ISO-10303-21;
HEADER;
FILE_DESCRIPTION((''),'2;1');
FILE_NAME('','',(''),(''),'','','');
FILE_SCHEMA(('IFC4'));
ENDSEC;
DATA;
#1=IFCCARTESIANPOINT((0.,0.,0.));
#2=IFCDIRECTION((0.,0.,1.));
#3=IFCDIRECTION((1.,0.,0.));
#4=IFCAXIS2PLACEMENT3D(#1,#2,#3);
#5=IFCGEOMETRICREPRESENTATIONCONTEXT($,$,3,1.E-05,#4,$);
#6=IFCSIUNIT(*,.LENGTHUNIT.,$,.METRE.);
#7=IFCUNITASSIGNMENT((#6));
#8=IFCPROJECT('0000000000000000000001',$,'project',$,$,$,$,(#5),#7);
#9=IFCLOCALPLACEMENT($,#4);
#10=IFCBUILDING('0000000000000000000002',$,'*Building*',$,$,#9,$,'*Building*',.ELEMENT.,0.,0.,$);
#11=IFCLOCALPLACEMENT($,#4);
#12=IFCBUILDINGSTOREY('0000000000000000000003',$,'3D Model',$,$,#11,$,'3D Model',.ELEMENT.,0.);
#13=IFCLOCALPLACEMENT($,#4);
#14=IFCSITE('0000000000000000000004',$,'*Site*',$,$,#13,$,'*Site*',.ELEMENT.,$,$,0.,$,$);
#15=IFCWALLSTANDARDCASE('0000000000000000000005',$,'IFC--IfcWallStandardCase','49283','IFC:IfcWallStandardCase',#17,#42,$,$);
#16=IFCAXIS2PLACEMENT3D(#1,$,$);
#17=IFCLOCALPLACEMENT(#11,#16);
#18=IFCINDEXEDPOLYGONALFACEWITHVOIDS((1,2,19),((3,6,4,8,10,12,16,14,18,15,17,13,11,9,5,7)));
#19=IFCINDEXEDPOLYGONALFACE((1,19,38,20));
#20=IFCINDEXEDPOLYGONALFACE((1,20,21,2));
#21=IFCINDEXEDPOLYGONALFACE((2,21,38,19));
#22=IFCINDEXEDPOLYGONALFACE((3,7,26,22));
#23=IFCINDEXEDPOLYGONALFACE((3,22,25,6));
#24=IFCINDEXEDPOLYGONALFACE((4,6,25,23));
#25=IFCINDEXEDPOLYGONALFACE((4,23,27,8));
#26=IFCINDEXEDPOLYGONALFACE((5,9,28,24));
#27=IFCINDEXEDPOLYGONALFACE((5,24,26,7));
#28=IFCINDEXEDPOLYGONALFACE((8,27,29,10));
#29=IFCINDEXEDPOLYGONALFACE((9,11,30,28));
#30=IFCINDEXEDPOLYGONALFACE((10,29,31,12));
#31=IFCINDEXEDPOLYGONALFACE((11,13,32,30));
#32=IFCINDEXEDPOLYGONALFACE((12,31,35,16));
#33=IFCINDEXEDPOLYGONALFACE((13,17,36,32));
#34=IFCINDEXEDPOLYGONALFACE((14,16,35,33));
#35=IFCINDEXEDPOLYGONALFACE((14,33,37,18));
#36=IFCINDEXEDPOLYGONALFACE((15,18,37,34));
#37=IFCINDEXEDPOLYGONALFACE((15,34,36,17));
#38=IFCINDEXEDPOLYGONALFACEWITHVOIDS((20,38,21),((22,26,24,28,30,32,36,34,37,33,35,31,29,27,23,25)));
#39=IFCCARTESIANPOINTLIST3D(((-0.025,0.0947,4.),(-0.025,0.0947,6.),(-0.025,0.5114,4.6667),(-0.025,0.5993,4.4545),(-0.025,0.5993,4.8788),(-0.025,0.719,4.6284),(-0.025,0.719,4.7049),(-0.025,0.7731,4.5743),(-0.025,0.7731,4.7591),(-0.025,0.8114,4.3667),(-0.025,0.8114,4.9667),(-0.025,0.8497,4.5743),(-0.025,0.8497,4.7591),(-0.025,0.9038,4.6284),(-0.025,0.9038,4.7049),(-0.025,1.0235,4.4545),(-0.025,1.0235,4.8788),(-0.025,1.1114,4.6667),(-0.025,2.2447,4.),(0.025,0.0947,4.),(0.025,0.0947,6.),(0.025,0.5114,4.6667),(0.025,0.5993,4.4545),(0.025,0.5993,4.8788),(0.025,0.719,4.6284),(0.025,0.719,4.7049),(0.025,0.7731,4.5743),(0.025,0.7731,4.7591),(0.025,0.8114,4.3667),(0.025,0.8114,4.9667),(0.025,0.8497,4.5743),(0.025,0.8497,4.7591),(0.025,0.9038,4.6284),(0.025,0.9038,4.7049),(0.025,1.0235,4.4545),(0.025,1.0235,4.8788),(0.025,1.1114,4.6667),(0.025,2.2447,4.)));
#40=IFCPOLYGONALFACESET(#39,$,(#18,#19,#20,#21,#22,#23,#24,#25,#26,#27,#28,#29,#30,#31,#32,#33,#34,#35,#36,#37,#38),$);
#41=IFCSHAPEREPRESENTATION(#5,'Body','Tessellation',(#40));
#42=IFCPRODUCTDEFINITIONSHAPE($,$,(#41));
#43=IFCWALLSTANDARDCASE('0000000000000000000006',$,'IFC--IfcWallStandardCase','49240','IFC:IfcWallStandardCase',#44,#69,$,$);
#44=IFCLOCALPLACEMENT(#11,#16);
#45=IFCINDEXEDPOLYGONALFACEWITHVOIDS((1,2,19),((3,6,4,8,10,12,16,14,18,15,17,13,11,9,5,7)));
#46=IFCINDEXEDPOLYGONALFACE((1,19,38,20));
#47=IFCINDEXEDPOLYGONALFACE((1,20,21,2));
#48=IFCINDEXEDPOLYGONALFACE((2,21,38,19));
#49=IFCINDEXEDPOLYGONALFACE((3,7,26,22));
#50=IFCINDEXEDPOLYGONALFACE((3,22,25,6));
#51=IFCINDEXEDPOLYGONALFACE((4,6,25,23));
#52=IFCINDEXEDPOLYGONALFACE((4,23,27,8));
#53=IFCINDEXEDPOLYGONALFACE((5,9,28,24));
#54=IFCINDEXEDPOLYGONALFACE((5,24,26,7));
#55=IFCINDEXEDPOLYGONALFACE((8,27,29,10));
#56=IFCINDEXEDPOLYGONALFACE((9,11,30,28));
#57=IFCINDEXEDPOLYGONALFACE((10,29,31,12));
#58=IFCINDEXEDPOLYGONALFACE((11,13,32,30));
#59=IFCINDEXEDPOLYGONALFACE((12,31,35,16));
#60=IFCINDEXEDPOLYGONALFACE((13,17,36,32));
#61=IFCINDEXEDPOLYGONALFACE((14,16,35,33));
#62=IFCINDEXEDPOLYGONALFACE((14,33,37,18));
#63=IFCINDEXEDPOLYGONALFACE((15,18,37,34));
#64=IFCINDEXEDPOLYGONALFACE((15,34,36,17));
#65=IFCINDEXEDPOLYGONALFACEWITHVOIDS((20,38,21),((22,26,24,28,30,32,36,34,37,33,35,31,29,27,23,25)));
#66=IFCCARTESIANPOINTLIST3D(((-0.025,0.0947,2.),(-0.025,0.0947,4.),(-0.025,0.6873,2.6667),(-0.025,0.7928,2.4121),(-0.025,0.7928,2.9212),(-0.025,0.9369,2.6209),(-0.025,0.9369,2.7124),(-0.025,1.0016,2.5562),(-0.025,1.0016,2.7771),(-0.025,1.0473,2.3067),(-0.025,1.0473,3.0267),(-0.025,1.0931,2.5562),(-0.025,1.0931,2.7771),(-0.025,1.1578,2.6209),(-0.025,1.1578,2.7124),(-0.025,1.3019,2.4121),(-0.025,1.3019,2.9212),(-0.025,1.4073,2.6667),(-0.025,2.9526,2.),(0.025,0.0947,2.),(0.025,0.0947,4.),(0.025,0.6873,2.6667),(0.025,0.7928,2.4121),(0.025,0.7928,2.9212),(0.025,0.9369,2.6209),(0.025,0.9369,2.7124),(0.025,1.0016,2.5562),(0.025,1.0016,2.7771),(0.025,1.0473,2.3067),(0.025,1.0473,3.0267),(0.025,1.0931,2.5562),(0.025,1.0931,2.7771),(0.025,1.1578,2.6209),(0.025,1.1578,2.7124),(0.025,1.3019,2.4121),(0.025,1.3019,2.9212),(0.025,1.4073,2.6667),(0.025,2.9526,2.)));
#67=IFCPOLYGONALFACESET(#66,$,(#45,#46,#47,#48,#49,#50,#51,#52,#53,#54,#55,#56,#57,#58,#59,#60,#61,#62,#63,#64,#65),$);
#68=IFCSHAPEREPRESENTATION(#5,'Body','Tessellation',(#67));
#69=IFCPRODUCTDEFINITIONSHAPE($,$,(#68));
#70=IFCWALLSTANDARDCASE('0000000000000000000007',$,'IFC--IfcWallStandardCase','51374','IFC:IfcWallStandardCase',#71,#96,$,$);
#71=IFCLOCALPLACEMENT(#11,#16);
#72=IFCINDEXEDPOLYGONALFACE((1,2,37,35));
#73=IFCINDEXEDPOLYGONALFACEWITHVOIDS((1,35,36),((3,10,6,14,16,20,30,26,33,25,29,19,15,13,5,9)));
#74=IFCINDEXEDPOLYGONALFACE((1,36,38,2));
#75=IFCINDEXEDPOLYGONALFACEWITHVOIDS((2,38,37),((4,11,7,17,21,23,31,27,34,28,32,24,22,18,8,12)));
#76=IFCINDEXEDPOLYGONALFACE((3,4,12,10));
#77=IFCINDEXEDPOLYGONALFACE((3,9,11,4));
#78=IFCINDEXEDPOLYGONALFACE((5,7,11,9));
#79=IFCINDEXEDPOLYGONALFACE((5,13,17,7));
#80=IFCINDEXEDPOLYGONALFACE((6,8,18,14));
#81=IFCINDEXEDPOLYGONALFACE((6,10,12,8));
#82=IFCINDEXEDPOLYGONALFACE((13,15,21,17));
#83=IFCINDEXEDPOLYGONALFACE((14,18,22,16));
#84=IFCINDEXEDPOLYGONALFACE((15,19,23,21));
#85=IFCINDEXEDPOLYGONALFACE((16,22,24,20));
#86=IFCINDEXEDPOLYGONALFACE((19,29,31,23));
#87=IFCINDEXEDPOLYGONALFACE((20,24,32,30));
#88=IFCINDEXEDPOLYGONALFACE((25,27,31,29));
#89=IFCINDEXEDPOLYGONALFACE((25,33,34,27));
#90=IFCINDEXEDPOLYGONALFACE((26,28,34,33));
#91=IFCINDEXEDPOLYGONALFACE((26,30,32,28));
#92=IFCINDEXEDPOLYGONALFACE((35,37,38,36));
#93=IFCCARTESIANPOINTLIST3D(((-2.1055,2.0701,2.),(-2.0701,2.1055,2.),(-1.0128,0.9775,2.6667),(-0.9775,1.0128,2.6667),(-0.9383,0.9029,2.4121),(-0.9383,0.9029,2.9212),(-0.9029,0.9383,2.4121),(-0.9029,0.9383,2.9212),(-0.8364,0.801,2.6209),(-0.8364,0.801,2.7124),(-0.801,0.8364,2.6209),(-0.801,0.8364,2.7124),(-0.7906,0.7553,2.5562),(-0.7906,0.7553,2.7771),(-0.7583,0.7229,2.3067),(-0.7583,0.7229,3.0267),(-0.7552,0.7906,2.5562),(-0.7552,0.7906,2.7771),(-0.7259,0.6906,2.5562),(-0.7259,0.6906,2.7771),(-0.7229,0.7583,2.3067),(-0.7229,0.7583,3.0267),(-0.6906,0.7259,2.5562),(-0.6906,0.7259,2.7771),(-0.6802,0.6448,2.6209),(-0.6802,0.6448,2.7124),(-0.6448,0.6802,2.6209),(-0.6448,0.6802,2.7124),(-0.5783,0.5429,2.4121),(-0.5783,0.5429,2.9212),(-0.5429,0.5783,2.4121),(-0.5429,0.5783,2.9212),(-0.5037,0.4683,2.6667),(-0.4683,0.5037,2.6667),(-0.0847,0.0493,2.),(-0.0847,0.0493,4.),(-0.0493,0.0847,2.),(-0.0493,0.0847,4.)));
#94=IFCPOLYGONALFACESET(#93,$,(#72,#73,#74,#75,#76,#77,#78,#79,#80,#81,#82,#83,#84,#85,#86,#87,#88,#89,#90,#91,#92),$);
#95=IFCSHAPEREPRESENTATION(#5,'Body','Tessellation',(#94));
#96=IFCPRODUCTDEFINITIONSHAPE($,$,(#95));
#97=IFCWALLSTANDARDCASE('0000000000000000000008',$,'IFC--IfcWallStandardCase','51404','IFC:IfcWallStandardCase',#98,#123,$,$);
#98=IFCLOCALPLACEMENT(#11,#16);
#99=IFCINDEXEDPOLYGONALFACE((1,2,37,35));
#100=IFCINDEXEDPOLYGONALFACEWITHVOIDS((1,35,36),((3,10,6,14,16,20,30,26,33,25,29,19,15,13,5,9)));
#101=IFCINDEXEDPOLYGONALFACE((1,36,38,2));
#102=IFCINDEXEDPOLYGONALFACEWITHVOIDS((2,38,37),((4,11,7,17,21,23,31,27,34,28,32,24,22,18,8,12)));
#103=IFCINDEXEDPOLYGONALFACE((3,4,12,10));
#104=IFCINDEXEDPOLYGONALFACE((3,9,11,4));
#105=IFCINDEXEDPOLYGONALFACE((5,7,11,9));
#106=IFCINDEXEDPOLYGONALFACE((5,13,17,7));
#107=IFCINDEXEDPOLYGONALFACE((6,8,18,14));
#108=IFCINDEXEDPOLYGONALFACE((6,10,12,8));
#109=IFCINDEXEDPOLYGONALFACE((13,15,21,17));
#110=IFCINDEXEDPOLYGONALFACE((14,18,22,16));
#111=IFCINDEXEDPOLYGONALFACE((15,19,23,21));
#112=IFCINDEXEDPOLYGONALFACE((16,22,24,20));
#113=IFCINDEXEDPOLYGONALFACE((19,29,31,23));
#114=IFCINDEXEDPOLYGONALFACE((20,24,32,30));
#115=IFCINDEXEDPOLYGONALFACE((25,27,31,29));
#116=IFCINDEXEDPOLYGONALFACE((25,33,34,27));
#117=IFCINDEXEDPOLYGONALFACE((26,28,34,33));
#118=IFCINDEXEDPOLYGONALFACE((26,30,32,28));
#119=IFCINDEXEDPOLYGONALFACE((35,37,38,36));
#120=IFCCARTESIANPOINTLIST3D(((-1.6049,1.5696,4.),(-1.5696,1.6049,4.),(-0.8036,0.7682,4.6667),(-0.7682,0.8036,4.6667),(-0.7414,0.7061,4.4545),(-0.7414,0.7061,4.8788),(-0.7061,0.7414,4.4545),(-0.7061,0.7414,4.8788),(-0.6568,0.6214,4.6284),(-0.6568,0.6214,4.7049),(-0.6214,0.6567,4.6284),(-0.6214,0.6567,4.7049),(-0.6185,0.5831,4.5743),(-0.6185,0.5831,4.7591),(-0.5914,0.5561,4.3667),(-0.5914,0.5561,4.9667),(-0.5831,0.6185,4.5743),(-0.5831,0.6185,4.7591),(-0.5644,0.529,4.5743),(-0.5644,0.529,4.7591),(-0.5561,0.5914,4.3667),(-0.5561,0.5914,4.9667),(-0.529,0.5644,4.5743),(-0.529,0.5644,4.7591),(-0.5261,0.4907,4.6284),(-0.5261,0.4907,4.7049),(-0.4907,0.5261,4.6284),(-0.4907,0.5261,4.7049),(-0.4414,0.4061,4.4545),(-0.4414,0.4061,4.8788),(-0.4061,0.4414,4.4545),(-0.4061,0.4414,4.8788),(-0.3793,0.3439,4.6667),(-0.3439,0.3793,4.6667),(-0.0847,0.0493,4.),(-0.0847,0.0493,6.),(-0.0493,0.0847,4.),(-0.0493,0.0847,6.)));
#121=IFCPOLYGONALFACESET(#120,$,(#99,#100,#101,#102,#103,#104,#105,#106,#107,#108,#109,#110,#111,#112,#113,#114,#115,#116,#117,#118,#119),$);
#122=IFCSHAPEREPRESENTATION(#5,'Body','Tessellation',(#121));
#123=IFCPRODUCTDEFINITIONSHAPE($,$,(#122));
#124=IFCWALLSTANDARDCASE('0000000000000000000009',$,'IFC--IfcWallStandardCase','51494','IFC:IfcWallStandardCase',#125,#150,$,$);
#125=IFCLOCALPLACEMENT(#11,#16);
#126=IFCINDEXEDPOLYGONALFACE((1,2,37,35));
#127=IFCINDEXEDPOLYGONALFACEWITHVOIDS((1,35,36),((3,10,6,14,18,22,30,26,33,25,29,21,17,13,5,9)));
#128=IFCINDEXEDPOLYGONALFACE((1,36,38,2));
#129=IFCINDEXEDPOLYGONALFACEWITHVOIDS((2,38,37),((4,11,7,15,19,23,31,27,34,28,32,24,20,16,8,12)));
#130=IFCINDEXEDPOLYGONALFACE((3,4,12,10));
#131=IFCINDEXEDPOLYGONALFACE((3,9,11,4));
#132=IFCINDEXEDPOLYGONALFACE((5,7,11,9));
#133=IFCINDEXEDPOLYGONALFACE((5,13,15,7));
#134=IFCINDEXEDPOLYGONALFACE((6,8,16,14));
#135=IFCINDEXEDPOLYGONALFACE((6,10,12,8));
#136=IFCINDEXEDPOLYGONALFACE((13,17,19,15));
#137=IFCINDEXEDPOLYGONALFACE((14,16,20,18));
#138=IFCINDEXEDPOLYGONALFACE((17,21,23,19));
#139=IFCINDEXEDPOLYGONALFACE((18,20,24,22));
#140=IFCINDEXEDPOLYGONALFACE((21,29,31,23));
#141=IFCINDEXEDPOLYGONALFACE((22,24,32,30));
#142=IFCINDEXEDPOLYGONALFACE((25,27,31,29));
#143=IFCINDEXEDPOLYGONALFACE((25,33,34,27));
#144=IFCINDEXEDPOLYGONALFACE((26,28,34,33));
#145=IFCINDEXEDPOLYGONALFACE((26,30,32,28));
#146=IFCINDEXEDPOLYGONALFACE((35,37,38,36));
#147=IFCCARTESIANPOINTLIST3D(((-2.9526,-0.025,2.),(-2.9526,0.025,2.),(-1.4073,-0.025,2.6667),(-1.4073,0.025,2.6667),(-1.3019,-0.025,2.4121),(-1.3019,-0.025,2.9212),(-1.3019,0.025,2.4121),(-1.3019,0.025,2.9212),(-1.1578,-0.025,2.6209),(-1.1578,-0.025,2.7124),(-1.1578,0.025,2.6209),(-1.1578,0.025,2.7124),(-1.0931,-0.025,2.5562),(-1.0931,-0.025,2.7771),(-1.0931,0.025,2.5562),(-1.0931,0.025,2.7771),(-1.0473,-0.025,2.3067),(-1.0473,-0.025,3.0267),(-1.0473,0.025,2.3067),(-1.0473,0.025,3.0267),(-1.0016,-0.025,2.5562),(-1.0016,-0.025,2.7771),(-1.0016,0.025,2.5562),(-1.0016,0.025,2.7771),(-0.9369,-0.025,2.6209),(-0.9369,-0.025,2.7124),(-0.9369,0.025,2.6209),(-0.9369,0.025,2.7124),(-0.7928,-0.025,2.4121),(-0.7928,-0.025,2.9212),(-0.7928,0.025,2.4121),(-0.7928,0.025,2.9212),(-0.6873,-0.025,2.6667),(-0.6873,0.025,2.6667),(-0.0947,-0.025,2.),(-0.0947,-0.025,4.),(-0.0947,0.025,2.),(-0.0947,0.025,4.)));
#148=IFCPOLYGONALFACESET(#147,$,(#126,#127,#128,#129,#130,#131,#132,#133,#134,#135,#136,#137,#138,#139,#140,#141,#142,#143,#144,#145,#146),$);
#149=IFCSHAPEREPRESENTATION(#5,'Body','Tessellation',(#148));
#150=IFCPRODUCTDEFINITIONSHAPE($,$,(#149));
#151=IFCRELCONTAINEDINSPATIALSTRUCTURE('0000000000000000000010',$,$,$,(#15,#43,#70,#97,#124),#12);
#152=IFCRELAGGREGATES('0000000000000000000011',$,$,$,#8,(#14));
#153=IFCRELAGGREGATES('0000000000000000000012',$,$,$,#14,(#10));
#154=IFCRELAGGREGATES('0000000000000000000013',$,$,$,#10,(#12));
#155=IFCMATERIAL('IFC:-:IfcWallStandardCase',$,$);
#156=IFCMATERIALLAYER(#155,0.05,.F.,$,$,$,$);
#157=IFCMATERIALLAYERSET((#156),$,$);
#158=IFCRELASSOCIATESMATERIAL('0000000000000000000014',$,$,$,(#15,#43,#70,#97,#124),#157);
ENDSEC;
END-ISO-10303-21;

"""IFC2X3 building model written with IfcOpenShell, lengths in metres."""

from ifc_helpers import new_model, si_unit, frame, frame_2d, origin_with_axes, place, context, project, spatial, polyline, rectangle, outline, extrude, clip, halfspace, material, layer, layer_set, layer_usage, element, save


model = new_model("IFC2X3")

# Units and contexts
context_of_model = context(None, 3, precision=1e-05, world=origin_with_axes())
ifc_project = project(units=[si_unit("LENGTHUNIT", "METRE")], contexts=[context_of_model])

# Site, building, storey
site_placement = place(None, origin_with_axes())
site = spatial("IfcSite", under=ifc_project, at=site_placement, Name="*Site*", LongName="*Site*", CompositionType="ELEMENT", RefElevation=0.0)
building_placement = place(None, origin_with_axes())
building = spatial("IfcBuilding", under=site, at=building_placement, Name="*Building*", LongName="*Building*", CompositionType="ELEMENT", ElevationOfRefHeight=0.0, ElevationOfTerrain=0.0)
storey_placement = place(None, origin_with_axes())
storey = spatial("IfcBuildingStorey", under=building, at=storey_placement, Name="3D Model", LongName="3D Model", CompositionType="ELEMENT", Elevation=0.0)

# Walls, openings
ifc_material = material(Name="IFC:-:IfcWallStandardCase")
ifc_layer = layer(ifc_material, 0.05, ventilated=False)
ifc_layer_set = layer_set([ifc_layer])
ifc_layer_usage = layer_usage(ifc_layer_set, "AXIS2", "POSITIVE", 0.0)
wall_1_placement = place(None, frame((0.0, 0.0947, 4.0), z_axis=(0.0, 0.0, 1.0), x_axis=(-0.000003, 1.0, 0.0)))
wall_1 = element("IfcWallStandardCase", 1, at=wall_1_placement, inside=storey, material=ifc_layer_usage, Name="IFC--IfcWallStandardCase", Description="49283", ObjectType="IFC:IfcWallStandardCase", context=context_of_model, shape_type="Clipping", body=[
    clip(extrude(rectangle(XDim=2.15, YDim=0.05, at=frame_2d((1.075, 0.0), x_axis=(1.0, 0.0))), origin_with_axes(), (0.0, 0.0, 1.0), 2.0), halfspace(frame((0.9974, 0.0, 1.0722), z_axis=(-0.681104, 0.000002, -0.732187), x_axis=(-0.732187, 0.0, 0.681104)), True)),
])
opening_1_placement = place(wall_1_placement, frame((0.4167, -0.025, 0.3667), z_axis=(0.0, 0.0, 1.0), x_axis=(1.0, 0.0, 0.0)))
element("IfcOpeningElement", 2, at=opening_1_placement, cuts=wall_1, context=context_of_model, shape_type="SweptSolid", body=[
    extrude(outline(polyline([(-0.3924, 0.2617), (-0.5121, 0.0879), (-0.3383, 0.2076), (-0.3, 0.0), (-0.2617, 0.2076), (-0.0879, 0.0879), (-0.2076, 0.2617), (0.0, 0.3), (-0.2076, 0.3383), (-0.0879, 0.5121), (-0.2617, 0.3924), (-0.3, 0.6), (-0.3383, 0.3924), (-0.5121, 0.5121), (-0.3924, 0.3383), (-0.6, 0.3), (-0.3924, 0.2617)])), frame((0.0, 0.0, 0.0), z_axis=(0.0, 1.0, 0.0), x_axis=(-1.0, 0.0, 0.0)), (0.0, 0.0, 1.0), 0.075),
])
wall_2_placement = place(None, frame((0.0, 0.0947, 2.0), z_axis=(0.0, 0.0, 1.0), x_axis=(0.0, 1.0, 0.0)))
wall_2 = element("IfcWallStandardCase", 3, at=wall_2_placement, inside=storey, material=ifc_layer_usage, Name="IFC--IfcWallStandardCase", Description="49240", ObjectType="IFC:IfcWallStandardCase", context=context_of_model, shape_type="Clipping", body=[
    clip(extrude(rectangle(XDim=2.8578, YDim=0.05, at=frame_2d((1.4289, 0.0), x_axis=(1.0, 0.0))), origin_with_axes(), (0.0, 0.0, 1.0), 2.0), halfspace(frame((0.9395, 0.0, 1.3425), z_axis=(-0.573369, 0.0, -0.819297), x_axis=(-0.819297, 0.0, 0.573369)), True)),
])
opening_2_placement = place(wall_2_placement, frame((0.5926, -0.025, 0.3067), z_axis=(0.0, 0.0, 1.0), x_axis=(1.0, 0.0, 0.0)))
element("IfcOpeningElement", 4, at=opening_2_placement, cuts=wall_2, context=context_of_model, shape_type="SweptSolid", body=[
    extrude(outline(polyline([(-0.4704, 0.3143), (-0.6146, 0.1054), (-0.4057, 0.2496), (-0.36, 0.0), (-0.3143, 0.2496), (-0.1054, 0.1054), (-0.2496, 0.3143), (0.0, 0.36), (-0.2496, 0.4057), (-0.1054, 0.6146), (-0.3143, 0.4704), (-0.36, 0.72), (-0.4057, 0.4704), (-0.6146, 0.6146), (-0.4704, 0.4057), (-0.72, 0.36), (-0.4704, 0.3143)])), frame((0.0, 0.0, 0.0), z_axis=(-0.000003, 1.0, 0.0), x_axis=(-1.0, -0.000003, 0.0)), (0.0, 0.0, 1.0), 0.075),
])
wall_3_placement = place(None, frame((-0.067, 0.067, 2.0), z_axis=(0.0, 0.0, 1.0), x_axis=(-0.707107, 0.707107, 0.0)))
wall_3 = element("IfcWallStandardCase", 5, at=wall_3_placement, inside=storey, material=ifc_layer_usage, Name="IFC--IfcWallStandardCase", Description="51374", ObjectType="IFC:IfcWallStandardCase", context=context_of_model, shape_type="Clipping", body=[
    clip(extrude(rectangle(XDim=2.8578, YDim=0.05, at=frame_2d((1.4289, 0.0), x_axis=(1.0, 0.0))), origin_with_axes(), (0.0, 0.0, 1.0), 2.0), halfspace(frame((0.9395, 0.0, 1.3425), z_axis=(-0.573369, 0.0, -0.819297), x_axis=(-0.819297, 0.0, 0.573369)), True)),
])
opening_3_placement = place(wall_3_placement, frame((0.5926, -0.025, 0.3067), z_axis=(0.0, 0.0, 1.0), x_axis=(1.0, 0.0, 0.0)))
element("IfcOpeningElement", 6, at=opening_3_placement, cuts=wall_3, context=context_of_model, shape_type="SweptSolid", body=[
    extrude(outline(polyline([(-0.4704, 0.3143), (-0.6146, 0.1054), (-0.4057, 0.2496), (-0.36, 0.0), (-0.3143, 0.2496), (-0.1054, 0.1054), (-0.2496, 0.3143), (0.0, 0.36), (-0.2496, 0.4057), (-0.1054, 0.6146), (-0.3143, 0.4704), (-0.36, 0.72), (-0.4057, 0.4704), (-0.6146, 0.6146), (-0.4704, 0.4057), (-0.72, 0.36), (-0.4704, 0.3143)])), frame((0.0, 0.0, 0.0), z_axis=(-0.000003, 1.0, 0.0), x_axis=(-1.0, -0.000003, 0.0)), (0.0, 0.0, 1.0), 0.075),
])
wall_4_placement = place(None, frame((-0.067, 0.067, 4.0), z_axis=(0.0, 0.0, 1.0), x_axis=(-0.707109, 0.707105, 0.0)))
wall_4 = element("IfcWallStandardCase", 7, at=wall_4_placement, inside=storey, material=ifc_layer_usage, Name="IFC--IfcWallStandardCase", Description="51404", ObjectType="IFC:IfcWallStandardCase", context=context_of_model, shape_type="Clipping", body=[
    clip(extrude(rectangle(XDim=2.15, YDim=0.05, at=frame_2d((1.075, 0.0), x_axis=(1.0, 0.0))), origin_with_axes(), (0.0, 0.0, 1.0), 2.0), halfspace(frame((0.9974, 0.0, 1.0722), z_axis=(-0.681104, 0.000002, -0.732187), x_axis=(-0.732187, 0.0, 0.681104)), True)),
])
opening_4_placement = place(wall_4_placement, frame((0.4167, -0.025, 0.3667), z_axis=(0.0, 0.0, 1.0), x_axis=(1.0, 0.0, 0.0)))
element("IfcOpeningElement", 8, at=opening_4_placement, cuts=wall_4, context=context_of_model, shape_type="SweptSolid", body=[
    extrude(outline(polyline([(-0.3924, 0.2617), (-0.5121, 0.0879), (-0.3383, 0.2076), (-0.3, 0.0), (-0.2617, 0.2076), (-0.0879, 0.0879), (-0.2076, 0.2617), (0.0, 0.3), (-0.2076, 0.3383), (-0.0879, 0.5121), (-0.2617, 0.3924), (-0.3, 0.6), (-0.3383, 0.3924), (-0.5121, 0.5121), (-0.3924, 0.3383), (-0.6, 0.3), (-0.3924, 0.2617)])), frame((0.0, 0.0, 0.0), z_axis=(0.0, 1.0, 0.0), x_axis=(-1.0, 0.0, 0.0)), (0.0, 0.0, 1.0), 0.075),
])
wall_5_placement = place(None, frame((-0.0947, 0.0, 2.0), z_axis=(0.0, 0.0, 1.0), x_axis=(-1.0, 0.0, 0.0)))
wall_5 = element("IfcWallStandardCase", 9, at=wall_5_placement, inside=storey, material=ifc_layer_usage, Name="IFC--IfcWallStandardCase", Description="51494", ObjectType="IFC:IfcWallStandardCase", context=context_of_model, shape_type="Clipping", body=[
    clip(extrude(rectangle(XDim=2.8578, YDim=0.05, at=frame_2d((1.4289, 0.0), x_axis=(1.0, 0.0))), origin_with_axes(), (0.0, 0.0, 1.0), 2.0), halfspace(frame((0.9395, 0.0, 1.3425), z_axis=(-0.573369, 0.0, -0.819297), x_axis=(-0.819297, 0.0, 0.573369)), True)),
])
opening_5_placement = place(wall_5_placement, frame((0.5926, -0.025, 0.3067), z_axis=(0.0, 0.0, 1.0), x_axis=(1.0, 0.0, 0.0)))
element("IfcOpeningElement", 10, at=opening_5_placement, cuts=wall_5, context=context_of_model, shape_type="SweptSolid", body=[
    extrude(outline(polyline([(-0.4704, 0.3143), (-0.6146, 0.1054), (-0.4057, 0.2496), (-0.36, 0.0), (-0.3143, 0.2496), (-0.1054, 0.1054), (-0.2496, 0.3143), (0.0, 0.36), (-0.2496, 0.4057), (-0.1054, 0.6146), (-0.3143, 0.4704), (-0.36, 0.72), (-0.4057, 0.4704), (-0.6146, 0.6146), (-0.4704, 0.4057), (-0.72, 0.36), (-0.4704, 0.3143)])), frame((0.0, 0.0, 0.0), z_axis=(-0.000003, 1.0, 0.0), x_axis=(-1.0, -0.000003, 0.0)), (0.0, 0.0, 1.0), 0.075),
])

save(model, "model.ifc")
